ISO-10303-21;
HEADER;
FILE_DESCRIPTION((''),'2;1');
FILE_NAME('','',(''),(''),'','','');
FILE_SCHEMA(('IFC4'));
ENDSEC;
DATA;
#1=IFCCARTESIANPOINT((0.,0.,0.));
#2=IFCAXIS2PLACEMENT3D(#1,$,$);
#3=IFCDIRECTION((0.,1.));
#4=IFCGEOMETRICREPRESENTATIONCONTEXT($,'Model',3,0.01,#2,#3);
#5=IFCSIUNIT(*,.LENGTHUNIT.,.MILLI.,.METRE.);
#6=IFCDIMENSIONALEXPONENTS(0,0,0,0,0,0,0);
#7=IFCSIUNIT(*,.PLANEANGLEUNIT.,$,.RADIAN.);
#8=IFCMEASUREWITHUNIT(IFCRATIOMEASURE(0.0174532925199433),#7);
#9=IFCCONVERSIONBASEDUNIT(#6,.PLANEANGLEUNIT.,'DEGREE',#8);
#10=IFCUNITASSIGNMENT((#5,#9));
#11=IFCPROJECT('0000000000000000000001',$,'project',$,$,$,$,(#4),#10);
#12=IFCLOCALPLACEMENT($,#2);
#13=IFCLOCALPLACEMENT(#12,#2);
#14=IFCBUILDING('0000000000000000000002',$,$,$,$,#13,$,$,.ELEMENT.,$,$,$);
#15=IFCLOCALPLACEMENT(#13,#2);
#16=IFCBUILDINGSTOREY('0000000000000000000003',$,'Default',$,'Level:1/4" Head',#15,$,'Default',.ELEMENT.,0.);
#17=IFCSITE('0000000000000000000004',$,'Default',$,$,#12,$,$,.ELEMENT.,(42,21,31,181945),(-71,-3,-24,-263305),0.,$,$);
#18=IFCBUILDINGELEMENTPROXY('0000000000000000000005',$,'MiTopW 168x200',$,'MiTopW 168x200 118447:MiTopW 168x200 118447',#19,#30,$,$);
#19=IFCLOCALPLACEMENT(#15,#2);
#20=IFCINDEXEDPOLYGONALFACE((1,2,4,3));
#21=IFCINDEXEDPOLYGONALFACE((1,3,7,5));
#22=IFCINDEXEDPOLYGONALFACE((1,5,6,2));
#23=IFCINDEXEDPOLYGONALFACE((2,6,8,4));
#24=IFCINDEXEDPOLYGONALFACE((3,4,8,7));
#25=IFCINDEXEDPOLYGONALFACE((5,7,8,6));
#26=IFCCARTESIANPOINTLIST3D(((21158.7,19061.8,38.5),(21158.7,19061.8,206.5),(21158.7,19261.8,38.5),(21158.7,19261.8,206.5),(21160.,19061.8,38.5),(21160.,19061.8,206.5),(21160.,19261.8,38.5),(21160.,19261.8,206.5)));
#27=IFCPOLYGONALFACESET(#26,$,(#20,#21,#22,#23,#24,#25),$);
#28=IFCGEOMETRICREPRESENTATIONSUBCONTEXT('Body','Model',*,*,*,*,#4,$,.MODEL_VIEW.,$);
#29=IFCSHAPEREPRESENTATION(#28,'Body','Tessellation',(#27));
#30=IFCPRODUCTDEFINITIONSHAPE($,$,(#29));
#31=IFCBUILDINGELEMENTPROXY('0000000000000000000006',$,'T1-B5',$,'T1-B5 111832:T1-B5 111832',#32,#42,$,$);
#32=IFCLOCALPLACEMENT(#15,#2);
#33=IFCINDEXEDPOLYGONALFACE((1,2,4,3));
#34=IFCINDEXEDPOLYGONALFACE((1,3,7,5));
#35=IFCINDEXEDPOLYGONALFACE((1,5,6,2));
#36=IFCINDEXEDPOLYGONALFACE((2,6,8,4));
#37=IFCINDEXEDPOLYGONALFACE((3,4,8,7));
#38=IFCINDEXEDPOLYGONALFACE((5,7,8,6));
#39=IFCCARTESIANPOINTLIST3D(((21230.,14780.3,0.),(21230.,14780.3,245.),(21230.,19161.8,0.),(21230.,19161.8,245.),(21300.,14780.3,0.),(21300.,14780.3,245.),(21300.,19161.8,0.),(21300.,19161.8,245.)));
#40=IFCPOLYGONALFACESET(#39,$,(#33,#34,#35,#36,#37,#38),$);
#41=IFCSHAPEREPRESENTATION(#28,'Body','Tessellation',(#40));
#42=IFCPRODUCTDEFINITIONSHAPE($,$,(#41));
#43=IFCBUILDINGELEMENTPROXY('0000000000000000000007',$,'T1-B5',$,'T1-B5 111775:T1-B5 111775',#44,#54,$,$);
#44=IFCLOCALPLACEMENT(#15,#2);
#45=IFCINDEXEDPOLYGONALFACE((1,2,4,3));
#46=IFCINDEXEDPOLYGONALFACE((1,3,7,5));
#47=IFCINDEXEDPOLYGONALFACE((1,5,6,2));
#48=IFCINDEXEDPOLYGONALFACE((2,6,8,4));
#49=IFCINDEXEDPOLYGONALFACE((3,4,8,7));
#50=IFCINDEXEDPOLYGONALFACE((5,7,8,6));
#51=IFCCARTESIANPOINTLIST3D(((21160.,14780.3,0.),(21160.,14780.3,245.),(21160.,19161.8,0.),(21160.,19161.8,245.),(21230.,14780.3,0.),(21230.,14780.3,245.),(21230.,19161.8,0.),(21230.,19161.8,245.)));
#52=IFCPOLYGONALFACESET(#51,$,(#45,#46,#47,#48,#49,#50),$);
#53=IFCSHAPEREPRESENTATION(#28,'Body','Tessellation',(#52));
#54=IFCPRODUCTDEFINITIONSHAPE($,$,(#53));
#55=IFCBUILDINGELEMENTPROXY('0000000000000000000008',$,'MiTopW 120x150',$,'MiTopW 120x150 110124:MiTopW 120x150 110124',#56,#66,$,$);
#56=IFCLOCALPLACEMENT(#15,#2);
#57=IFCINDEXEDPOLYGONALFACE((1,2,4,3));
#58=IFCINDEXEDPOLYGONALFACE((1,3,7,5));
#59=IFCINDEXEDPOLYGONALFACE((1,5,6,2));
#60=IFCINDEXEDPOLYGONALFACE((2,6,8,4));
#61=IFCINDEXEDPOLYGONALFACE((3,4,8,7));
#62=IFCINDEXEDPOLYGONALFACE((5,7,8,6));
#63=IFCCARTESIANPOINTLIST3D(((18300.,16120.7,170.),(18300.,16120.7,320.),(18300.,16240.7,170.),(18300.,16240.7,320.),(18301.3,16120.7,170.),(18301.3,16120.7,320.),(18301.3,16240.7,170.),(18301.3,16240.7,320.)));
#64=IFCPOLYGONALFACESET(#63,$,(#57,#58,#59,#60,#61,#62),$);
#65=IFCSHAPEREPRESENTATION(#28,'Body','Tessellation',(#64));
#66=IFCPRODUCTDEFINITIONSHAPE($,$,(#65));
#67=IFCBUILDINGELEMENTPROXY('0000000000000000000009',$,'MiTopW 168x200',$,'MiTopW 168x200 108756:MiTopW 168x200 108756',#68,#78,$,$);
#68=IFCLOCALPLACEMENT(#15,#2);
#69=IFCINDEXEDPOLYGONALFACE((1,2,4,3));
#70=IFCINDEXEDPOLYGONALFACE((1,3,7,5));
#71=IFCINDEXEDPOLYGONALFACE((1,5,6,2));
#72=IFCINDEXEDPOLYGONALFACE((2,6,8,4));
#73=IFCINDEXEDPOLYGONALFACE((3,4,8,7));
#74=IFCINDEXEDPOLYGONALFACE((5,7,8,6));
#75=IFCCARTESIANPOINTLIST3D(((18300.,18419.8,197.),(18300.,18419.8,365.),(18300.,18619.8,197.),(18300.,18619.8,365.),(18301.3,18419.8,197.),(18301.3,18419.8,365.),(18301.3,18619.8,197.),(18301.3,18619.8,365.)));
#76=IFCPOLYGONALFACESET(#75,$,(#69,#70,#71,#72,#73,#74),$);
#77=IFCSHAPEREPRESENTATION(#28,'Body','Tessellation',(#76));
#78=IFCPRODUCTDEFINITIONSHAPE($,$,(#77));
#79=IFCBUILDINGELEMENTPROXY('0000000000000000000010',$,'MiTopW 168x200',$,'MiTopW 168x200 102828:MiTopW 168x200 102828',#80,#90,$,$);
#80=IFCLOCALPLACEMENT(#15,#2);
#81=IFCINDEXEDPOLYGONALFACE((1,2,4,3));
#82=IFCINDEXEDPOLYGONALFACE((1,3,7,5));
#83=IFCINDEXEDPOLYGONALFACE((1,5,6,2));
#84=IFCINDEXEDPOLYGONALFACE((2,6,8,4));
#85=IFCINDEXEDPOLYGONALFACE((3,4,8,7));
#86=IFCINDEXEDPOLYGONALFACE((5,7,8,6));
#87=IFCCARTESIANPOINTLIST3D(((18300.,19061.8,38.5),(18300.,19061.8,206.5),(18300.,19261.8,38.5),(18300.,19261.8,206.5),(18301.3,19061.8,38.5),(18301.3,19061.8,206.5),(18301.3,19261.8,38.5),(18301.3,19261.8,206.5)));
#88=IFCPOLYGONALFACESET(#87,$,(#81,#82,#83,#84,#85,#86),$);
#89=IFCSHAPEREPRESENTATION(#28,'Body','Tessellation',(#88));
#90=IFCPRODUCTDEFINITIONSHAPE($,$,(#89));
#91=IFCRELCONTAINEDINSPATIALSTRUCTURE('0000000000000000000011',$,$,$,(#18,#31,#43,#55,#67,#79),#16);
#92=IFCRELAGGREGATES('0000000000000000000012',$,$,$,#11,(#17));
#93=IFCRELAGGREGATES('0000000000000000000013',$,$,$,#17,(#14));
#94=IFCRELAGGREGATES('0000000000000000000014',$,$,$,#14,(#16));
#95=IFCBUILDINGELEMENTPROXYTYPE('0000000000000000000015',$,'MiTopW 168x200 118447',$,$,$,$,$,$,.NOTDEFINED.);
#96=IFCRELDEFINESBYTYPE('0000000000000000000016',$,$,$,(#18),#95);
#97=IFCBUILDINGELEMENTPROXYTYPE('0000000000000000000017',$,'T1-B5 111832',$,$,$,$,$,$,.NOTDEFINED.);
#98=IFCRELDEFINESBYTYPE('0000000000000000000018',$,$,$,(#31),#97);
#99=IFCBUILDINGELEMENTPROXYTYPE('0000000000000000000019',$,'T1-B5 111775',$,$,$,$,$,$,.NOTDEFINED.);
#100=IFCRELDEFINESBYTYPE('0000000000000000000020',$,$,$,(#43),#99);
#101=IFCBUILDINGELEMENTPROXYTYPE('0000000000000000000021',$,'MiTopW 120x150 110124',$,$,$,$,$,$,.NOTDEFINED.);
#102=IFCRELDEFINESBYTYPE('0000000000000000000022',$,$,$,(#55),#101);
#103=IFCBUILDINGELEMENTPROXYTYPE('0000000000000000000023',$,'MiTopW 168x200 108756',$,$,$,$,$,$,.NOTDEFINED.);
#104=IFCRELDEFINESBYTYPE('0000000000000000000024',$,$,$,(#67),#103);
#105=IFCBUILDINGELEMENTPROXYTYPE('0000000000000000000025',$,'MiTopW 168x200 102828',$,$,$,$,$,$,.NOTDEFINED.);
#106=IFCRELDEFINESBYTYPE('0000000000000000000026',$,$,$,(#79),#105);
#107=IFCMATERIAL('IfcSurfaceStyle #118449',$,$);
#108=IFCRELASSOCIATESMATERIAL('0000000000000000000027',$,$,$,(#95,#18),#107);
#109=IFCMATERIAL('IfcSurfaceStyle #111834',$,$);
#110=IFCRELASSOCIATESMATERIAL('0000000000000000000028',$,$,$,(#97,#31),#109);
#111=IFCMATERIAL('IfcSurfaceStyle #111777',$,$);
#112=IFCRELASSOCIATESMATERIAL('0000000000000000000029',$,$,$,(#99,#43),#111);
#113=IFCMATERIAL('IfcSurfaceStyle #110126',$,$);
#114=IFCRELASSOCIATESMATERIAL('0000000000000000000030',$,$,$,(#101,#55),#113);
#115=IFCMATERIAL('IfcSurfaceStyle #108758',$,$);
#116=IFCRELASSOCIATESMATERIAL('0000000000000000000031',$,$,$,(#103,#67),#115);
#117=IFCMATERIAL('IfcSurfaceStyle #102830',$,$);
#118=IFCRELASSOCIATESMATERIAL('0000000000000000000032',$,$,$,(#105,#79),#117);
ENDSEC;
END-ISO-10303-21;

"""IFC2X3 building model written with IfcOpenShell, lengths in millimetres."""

from ifc_helpers import new_model, entity, si_unit, converted_unit, direction, frame, origin, origin_2d_with_axis, place, context, subcontext, project, spatial, rectangle, extrude, source, transform, mapped, material, type_object, type_shapes, element, save


model = new_model("IFC2X3")

# Units and contexts
model_context = context("Model", 3, precision=0.01, world=origin(), true_north=direction((0.0, 1.0)))
body_context = subcontext(model_context, "Body", "Model", "MODEL_VIEW")
ifc_project = project(units=[si_unit("LENGTHUNIT", "METRE", prefix="MILLI"), converted_unit("PLANEANGLEUNIT", "DEGREE", entity("IfcRatioMeasure", 0.0174532925199433), si_unit("PLANEANGLEUNIT", "RADIAN"), dimensions=[0, 0, 0, 0, 0, 0, 0])], contexts=[model_context])

# Site, building, storey
site_placement = place(None, origin())
site = spatial("IfcSite", under=ifc_project, at=site_placement, Name="Default", CompositionType="ELEMENT", RefLatitude=(42, 21, 31, 181945), RefLongitude=(-71, -3, -24, -263305), RefElevation=0.0)
building_placement = place(site_placement, origin())
building = spatial("IfcBuilding", under=site, at=building_placement, CompositionType="ELEMENT")
storey_placement = place(building_placement, origin())
storey = spatial("IfcBuildingStorey", under=building, at=storey_placement, Name="Default", ObjectType="Level:1/4\" Head", LongName="Default", CompositionType="ELEMENT", Elevation=0.0)

# Building element proxies
ifc_material_1 = material(Name="IfcSurfaceStyle #118449")
building_element_proxy_type_1 = type_object("IfcBuildingElementProxyType", Name="MiTopW 168x200 118447", PredefinedType="NOTDEFINED", material=ifc_material_1)
shared_shape_1 = source(origin(), body_context, "Body", "SweptSolid", [
    extrude(rectangle(XDim=200.0, YDim=168.0, at=origin_2d_with_axis()), frame((100.0, 84.0, 0.0), z_axis=(0.0, 0.0, 1.0), x_axis=(-1.0, 0.0, 0.0)), (0.0, 0.0, 1.0), 1.3),
])
type_shapes(building_element_proxy_type_1, [shared_shape_1])
proxy_1_placement = place(building_placement, frame((21160.0, 19061.8, 206.5), z_axis=(-1.0, 0.0, 0.0), x_axis=(0.0, 1.0, 0.0)))
element("IfcBuildingElementProxy", 1, at=proxy_1_placement, inside=storey, type_object=building_element_proxy_type_1, material=ifc_material_1, Name="MiTopW 168x200", ObjectType="MiTopW 168x200 118447:MiTopW 168x200 118447", context=body_context, shape_type="MappedRepresentation", body=[
    mapped(shared_shape_1, transform((0.0, 0.0, 0.0), scale=1.0)),
])
ifc_material_2 = material(Name="IfcSurfaceStyle #111834")
building_element_proxy_type_2 = type_object("IfcBuildingElementProxyType", Name="T1-B5 111832", PredefinedType="NOTDEFINED", material=ifc_material_2)
shared_shape_2 = source(origin(), body_context, "Body", "SweptSolid", [
    extrude(rectangle(XDim=4381.5, YDim=245.0, at=origin_2d_with_axis()), frame((2190.8, 122.5, 0.0), z_axis=(0.0, 0.0, 1.0), x_axis=(-1.0, 0.0, 0.0)), (0.0, 0.0, 1.0), 70.0),
])
type_shapes(building_element_proxy_type_2, [shared_shape_2])
proxy_2_placement = place(building_placement, frame((21300.0, 14780.3, 245.0), z_axis=(-1.0, 0.0, 0.0), x_axis=(0.0, 1.0, 0.0)))
element("IfcBuildingElementProxy", 2, at=proxy_2_placement, inside=storey, type_object=building_element_proxy_type_2, material=ifc_material_2, Name="T1-B5", ObjectType="T1-B5 111832:T1-B5 111832", context=body_context, shape_type="MappedRepresentation", body=[
    mapped(shared_shape_2, transform((0.0, 0.0, 0.0), scale=1.0)),
])
ifc_material_3 = material(Name="IfcSurfaceStyle #111777")
building_element_proxy_type_3 = type_object("IfcBuildingElementProxyType", Name="T1-B5 111775", PredefinedType="NOTDEFINED", material=ifc_material_3)
shared_shape_3 = source(origin(), body_context, "Body", "SweptSolid", [
    extrude(rectangle(XDim=4381.5, YDim=245.0, at=origin_2d_with_axis()), frame((2190.8, 122.5, 0.0), z_axis=(0.0, 0.0, 1.0), x_axis=(-1.0, 0.0, 0.0)), (0.0, 0.0, 1.0), 70.0),
])
type_shapes(building_element_proxy_type_3, [shared_shape_3])
proxy_3_placement = place(building_placement, frame((21230.0, 14780.3, 245.0), z_axis=(-1.0, 0.0, 0.0), x_axis=(0.0, 1.0, 0.0)))
element("IfcBuildingElementProxy", 3, at=proxy_3_placement, inside=storey, type_object=building_element_proxy_type_3, material=ifc_material_3, Name="T1-B5", ObjectType="T1-B5 111775:T1-B5 111775", context=body_context, shape_type="MappedRepresentation", body=[
    mapped(shared_shape_3, transform((0.0, 0.0, 0.0), scale=1.0)),
])
ifc_material_4 = material(Name="IfcSurfaceStyle #110126")
building_element_proxy_type_4 = type_object("IfcBuildingElementProxyType", Name="MiTopW 120x150 110124", PredefinedType="NOTDEFINED", material=ifc_material_4)
shared_shape_4 = source(origin(), body_context, "Body", "SweptSolid", [
    extrude(rectangle(XDim=150.0, YDim=120.0, at=origin_2d_with_axis()), frame((75.0, 60.0, 0.0), z_axis=(0.0, 0.0, 1.0), x_axis=(-1.0, 0.0, 0.0)), (0.0, 0.0, 1.0), 1.3),
])
type_shapes(building_element_proxy_type_4, [shared_shape_4])
proxy_4_placement = place(building_placement, frame((18301.3, 16120.7, 170.0), z_axis=(-1.0, 0.0, 0.0), x_axis=(0.0, 0.0, 1.0)))
element("IfcBuildingElementProxy", 4, at=proxy_4_placement, inside=storey, type_object=building_element_proxy_type_4, material=ifc_material_4, Name="MiTopW 120x150", ObjectType="MiTopW 120x150 110124:MiTopW 120x150 110124", context=body_context, shape_type="MappedRepresentation", body=[
    mapped(shared_shape_4, transform((0.0, 0.0, 0.0), scale=1.0)),
])
ifc_material_5 = material(Name="IfcSurfaceStyle #108758")
building_element_proxy_type_5 = type_object("IfcBuildingElementProxyType", Name="MiTopW 168x200 108756", PredefinedType="NOTDEFINED", material=ifc_material_5)
shared_shape_5 = source(origin(), body_context, "Body", "SweptSolid", [
    extrude(rectangle(XDim=200.0, YDim=168.0, at=origin_2d_with_axis()), frame((100.0, 84.0, 0.0), z_axis=(0.0, 0.0, 1.0), x_axis=(-1.0, 0.0, 0.0)), (0.0, 0.0, 1.0), 1.3),
])
type_shapes(building_element_proxy_type_5, [shared_shape_5])
proxy_5_placement = place(building_placement, frame((18301.3, 18619.8, 197.0), z_axis=(-1.0, 0.0, 0.0), x_axis=(0.0, -1.0, 0.0)))
element("IfcBuildingElementProxy", 5, at=proxy_5_placement, inside=storey, type_object=building_element_proxy_type_5, material=ifc_material_5, Name="MiTopW 168x200", ObjectType="MiTopW 168x200 108756:MiTopW 168x200 108756", context=body_context, shape_type="MappedRepresentation", body=[
    mapped(shared_shape_5, transform((0.0, 0.0, 0.0), scale=1.0)),
])
ifc_material_6 = material(Name="IfcSurfaceStyle #102830")
building_element_proxy_type_6 = type_object("IfcBuildingElementProxyType", Name="MiTopW 168x200 102828", PredefinedType="NOTDEFINED", material=ifc_material_6)
shared_shape_6 = source(origin(), body_context, "Body", "SweptSolid", [
    extrude(rectangle(XDim=200.0, YDim=168.0, at=origin_2d_with_axis()), frame((100.0, 84.0, 0.0), z_axis=(0.0, 0.0, 1.0), x_axis=(-1.0, 0.0, 0.0)), (0.0, 0.0, 1.0), 1.3),
])
type_shapes(building_element_proxy_type_6, [shared_shape_6])
proxy_6_placement = place(building_placement, frame((18301.3, 19061.8, 206.5), z_axis=(-1.0, 0.0, 0.0), x_axis=(0.0, 1.0, 0.0)))
element("IfcBuildingElementProxy", 6, at=proxy_6_placement, inside=storey, type_object=building_element_proxy_type_6, material=ifc_material_6, Name="MiTopW 168x200", ObjectType="MiTopW 168x200 102828:MiTopW 168x200 102828", context=body_context, shape_type="MappedRepresentation", body=[
    mapped(shared_shape_6, transform((0.0, 0.0, 0.0), scale=1.0)),
])

save(model, "model.ifc")
